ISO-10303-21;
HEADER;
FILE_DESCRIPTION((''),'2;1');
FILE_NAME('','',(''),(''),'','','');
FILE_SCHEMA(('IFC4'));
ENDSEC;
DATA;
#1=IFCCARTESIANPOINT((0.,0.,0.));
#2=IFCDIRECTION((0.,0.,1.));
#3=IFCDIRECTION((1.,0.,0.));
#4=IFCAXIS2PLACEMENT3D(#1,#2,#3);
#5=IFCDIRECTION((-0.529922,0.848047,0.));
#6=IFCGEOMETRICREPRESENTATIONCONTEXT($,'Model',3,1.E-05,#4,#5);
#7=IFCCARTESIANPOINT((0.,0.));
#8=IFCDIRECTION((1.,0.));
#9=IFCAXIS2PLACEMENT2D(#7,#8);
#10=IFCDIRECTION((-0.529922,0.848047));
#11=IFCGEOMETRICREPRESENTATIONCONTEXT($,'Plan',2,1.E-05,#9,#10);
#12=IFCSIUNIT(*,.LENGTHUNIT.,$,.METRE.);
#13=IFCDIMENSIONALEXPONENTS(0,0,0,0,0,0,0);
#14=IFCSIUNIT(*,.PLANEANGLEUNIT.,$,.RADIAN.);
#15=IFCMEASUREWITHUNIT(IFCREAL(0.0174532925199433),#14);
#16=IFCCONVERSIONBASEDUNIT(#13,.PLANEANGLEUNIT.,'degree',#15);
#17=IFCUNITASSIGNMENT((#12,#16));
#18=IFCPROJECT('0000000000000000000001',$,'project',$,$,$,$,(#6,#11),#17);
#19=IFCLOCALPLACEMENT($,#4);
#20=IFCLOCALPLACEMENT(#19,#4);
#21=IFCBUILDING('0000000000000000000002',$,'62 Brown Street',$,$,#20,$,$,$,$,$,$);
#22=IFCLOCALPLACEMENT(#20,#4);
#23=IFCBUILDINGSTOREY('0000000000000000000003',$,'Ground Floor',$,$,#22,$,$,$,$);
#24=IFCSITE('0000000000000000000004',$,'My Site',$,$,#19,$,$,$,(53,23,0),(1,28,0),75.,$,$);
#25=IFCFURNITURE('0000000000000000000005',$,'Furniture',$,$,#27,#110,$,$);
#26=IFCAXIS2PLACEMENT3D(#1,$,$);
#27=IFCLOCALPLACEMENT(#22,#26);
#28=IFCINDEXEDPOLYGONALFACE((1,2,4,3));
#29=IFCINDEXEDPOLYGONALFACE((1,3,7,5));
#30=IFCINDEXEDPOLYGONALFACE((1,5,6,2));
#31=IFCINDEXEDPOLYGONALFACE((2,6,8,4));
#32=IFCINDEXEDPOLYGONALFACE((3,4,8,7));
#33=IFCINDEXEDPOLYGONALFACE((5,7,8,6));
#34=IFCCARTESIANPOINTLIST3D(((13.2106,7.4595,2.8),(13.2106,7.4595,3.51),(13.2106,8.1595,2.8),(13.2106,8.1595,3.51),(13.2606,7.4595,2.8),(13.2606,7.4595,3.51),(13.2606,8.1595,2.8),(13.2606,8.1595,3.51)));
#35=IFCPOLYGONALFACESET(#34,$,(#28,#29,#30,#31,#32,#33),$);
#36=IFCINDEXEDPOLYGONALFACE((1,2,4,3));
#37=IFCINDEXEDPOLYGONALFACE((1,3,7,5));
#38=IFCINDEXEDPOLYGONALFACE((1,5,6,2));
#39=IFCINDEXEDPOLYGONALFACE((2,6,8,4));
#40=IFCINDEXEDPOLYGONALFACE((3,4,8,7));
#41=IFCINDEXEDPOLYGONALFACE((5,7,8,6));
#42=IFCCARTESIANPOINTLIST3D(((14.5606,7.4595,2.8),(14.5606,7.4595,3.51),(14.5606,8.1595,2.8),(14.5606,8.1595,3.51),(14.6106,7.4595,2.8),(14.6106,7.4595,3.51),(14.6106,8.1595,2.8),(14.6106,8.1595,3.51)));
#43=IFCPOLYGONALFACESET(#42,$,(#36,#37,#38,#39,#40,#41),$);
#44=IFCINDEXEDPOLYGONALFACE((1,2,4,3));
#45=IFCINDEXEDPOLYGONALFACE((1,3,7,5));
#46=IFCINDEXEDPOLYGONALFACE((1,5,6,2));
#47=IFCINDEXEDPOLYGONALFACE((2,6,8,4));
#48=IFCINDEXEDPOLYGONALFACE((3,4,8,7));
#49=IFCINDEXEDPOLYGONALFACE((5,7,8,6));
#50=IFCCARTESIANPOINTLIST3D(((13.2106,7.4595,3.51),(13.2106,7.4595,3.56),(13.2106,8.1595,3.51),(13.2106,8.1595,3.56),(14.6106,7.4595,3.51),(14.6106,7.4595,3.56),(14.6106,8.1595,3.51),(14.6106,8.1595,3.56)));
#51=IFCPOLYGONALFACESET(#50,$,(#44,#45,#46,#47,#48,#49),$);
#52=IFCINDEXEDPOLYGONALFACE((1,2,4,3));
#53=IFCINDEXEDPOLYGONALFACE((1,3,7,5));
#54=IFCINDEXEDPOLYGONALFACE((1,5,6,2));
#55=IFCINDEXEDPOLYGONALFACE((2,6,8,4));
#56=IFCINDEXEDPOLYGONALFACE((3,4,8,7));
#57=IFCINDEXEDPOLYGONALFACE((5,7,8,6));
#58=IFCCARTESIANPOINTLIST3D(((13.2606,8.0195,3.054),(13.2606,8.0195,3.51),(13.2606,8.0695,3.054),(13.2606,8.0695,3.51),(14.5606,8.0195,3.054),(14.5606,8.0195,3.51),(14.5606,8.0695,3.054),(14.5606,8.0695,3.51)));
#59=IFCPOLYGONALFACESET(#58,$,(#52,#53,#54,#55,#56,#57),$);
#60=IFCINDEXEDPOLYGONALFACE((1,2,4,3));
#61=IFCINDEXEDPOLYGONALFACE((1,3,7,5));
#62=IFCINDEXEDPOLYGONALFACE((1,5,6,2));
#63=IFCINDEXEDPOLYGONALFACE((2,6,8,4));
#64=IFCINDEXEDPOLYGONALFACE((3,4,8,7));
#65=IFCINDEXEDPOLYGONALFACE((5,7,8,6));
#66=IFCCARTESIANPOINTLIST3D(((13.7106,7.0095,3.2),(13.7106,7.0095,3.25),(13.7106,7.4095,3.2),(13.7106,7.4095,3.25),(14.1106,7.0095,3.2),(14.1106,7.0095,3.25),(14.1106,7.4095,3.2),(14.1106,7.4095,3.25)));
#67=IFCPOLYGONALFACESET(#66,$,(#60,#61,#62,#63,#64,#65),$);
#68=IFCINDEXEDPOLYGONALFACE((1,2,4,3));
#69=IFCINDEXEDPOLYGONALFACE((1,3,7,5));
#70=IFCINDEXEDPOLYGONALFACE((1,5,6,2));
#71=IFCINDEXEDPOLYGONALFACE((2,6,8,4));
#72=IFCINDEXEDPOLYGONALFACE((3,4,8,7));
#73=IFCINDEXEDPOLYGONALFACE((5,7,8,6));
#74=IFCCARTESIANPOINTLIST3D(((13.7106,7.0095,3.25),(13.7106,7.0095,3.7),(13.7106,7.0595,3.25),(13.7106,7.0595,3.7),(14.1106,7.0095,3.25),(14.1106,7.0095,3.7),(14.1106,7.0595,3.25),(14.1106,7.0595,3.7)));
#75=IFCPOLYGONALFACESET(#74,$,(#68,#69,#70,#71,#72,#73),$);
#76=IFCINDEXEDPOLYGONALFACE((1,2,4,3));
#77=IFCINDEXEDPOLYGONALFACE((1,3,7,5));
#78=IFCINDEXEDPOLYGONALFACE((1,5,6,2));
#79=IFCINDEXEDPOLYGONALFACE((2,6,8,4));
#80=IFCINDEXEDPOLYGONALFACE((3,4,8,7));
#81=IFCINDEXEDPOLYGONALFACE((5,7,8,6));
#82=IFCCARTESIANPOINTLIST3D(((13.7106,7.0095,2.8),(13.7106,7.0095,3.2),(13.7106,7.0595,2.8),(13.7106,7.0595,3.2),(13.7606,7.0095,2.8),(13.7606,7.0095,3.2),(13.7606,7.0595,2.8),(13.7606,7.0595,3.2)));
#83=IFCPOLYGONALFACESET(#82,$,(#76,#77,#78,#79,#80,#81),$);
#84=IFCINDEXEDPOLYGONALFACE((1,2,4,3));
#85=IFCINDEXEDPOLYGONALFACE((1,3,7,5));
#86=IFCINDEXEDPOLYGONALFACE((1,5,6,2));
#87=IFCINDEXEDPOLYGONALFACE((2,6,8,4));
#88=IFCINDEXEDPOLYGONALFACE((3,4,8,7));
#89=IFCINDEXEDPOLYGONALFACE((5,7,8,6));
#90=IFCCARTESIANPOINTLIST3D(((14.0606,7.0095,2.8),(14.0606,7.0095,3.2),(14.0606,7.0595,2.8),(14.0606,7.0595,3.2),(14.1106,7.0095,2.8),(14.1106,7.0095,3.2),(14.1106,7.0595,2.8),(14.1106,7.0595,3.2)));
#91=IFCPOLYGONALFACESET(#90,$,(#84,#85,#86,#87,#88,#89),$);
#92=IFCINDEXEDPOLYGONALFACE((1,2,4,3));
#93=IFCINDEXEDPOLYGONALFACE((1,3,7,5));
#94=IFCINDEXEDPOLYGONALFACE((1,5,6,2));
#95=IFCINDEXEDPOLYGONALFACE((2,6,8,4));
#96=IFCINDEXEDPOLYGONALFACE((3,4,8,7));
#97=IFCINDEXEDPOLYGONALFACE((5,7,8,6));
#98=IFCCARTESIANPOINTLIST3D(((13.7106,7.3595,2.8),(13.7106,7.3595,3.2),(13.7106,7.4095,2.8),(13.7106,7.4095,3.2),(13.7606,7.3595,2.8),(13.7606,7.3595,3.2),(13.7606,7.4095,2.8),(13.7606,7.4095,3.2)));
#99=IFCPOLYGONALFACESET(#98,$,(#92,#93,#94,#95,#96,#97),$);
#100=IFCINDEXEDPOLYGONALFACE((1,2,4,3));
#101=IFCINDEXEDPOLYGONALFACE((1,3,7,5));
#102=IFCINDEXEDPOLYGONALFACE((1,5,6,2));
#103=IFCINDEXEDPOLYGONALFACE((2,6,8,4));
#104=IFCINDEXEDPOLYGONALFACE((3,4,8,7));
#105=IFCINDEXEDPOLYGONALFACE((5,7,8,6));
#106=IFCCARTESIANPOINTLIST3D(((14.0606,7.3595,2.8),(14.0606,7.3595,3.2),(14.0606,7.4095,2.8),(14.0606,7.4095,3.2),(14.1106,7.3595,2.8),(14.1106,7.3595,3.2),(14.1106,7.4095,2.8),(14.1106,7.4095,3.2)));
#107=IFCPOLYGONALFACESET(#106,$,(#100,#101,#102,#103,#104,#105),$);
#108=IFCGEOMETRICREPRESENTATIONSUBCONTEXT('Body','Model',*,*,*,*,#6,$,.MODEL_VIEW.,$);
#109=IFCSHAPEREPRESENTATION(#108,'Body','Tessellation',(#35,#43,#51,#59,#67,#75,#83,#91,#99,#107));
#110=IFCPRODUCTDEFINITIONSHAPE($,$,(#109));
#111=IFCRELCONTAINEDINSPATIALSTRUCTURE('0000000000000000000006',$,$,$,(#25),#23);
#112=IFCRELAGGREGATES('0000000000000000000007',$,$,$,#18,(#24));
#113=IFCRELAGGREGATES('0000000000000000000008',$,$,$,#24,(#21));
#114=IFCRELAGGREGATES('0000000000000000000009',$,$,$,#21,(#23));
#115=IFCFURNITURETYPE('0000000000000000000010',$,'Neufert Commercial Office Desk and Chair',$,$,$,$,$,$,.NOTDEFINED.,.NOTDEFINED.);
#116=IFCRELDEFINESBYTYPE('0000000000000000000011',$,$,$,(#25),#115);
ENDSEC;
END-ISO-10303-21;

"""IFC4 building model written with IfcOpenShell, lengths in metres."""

from ifc_helpers import new_model, entity, si_unit, converted_unit, direction, frame, origin_with_axes, origin_2d_with_axis, place, context, subcontext, project, spatial, line, indexed_curve, outline, extrude, shape, source, transform, mapped, type_object, type_shapes, element, save


model = new_model("IFC4")

# Units and contexts
model_context = context("Model", 3, precision=1e-05, world=origin_with_axes(), true_north=direction((-0.529922, 0.848047, 0.0)))
plan_context = context("Plan", 2, precision=1e-05, world=origin_2d_with_axis(), true_north=direction((-0.529922, 0.848047)))
body_context_1 = subcontext(model_context, "Body", "Model", "MODEL_VIEW")
body_context_2 = subcontext(plan_context, "Body", "Plan", "PLAN_VIEW")
ifc_project = project(units=[si_unit("LENGTHUNIT", "METRE"), converted_unit("PLANEANGLEUNIT", "degree", entity("IfcReal", 0.0174532925199433), si_unit("PLANEANGLEUNIT", "RADIAN"), dimensions=[0, 0, 0, 0, 0, 0, 0])], contexts=[model_context, plan_context])

# Site, building, storey
site_placement = place(None, origin_with_axes())
site = spatial("IfcSite", under=ifc_project, at=site_placement, Name="My Site", RefLatitude=(53, 23, 0), RefLongitude=(1, 28, 0), RefElevation=75.0)
building_placement = place(site_placement, origin_with_axes())
building = spatial("IfcBuilding", under=site, at=building_placement, Name="62 Brown Street")
storey_placement = place(building_placement, origin_with_axes())
storey = spatial("IfcBuildingStorey", under=building, at=storey_placement, Name="Ground Floor")

# Furniture
furniture_type_1 = type_object("IfcFurnitureType", Name="Neufert Commercial Office Desk and Chair", AssemblyPlace="NOTDEFINED", PredefinedType="NOTDEFINED")
shared_shape_1 = source(origin_with_axes(), body_context_1, "Body", "SweptSolid", [
    extrude(outline(indexed_curve([(0.0, 0.0), (0.05, 0.0), (0.05, 0.7), (0.0, 0.7)], segments=[line(1, 2, 3, 4, 1)])), frame((0.0, 0.45, 0.0), z_axis=(0.0, 0.0, 1.0), x_axis=(1.0, 0.0, 0.0)), (0.0, 0.0, 1.0), 0.71),
    extrude(outline(indexed_curve([(0.0, 0.0), (0.05, 0.0), (0.05, 0.7), (0.0, 0.7)], segments=[line(1, 2, 3, 4, 1)])), frame((1.35, 0.45, 0.0), z_axis=(0.0, 0.0, 1.0), x_axis=(1.0, 0.0, 0.0)), (0.0, 0.0, 1.0), 0.71),
    extrude(outline(indexed_curve([(0.0, 0.0), (1.4, 0.0), (1.4, 0.7), (0.0, 0.7)], segments=[line(1, 2, 3, 4, 1)])), frame((0.0, 0.45, 0.71), z_axis=(0.0, 0.0, 1.0), x_axis=(1.0, 0.0, 0.0)), (0.0, 0.0, 1.0), 0.05),
    extrude(outline(indexed_curve([(0.05, 0.56), (1.35, 0.56), (1.35, 0.61), (0.05, 0.61)], segments=[line(1, 2, 3, 4, 1)])), frame((0.0, 0.45, 0.254), z_axis=(0.0, 0.0, 1.0), x_axis=(1.0, 0.0, 0.0)), (0.0, 0.0, 1.0), 0.456),
    extrude(outline(indexed_curve([(-0.2, 0.0), (0.2, 0.0), (0.2, 0.4), (-0.2, 0.4)], segments=[line(1, 2, 3, 4, 1)])), frame((0.7, 0.0, 0.45), z_axis=(0.0, 0.0, 1.0), x_axis=(1.0, 0.0, 0.0)), (0.0, 0.0, -1.0), 0.05),
    extrude(outline(indexed_curve([(-0.2, 0.0), (0.2, 0.0), (0.2, 0.05), (-0.2, 0.05)], segments=[line(1, 2, 3, 4, 1)])), frame((0.7, 0.0, 0.9), z_axis=(0.0, 0.0, 1.0), x_axis=(1.0, 0.0, 0.0)), (0.0, 0.0, -1.0), 0.45),
    extrude(outline(indexed_curve([(-0.2, 0.0), (-0.15, 0.0), (-0.15, 0.05), (-0.2, 0.05)], segments=[line(1, 2, 3, 4, 1)])), frame((0.7, 0.0, 0.0), z_axis=(0.0, 0.0, 1.0), x_axis=(1.0, 0.0, 0.0)), (0.0, 0.0, 1.0), 0.4),
    extrude(outline(indexed_curve([(0.2, 0.0), (0.15, 0.0), (0.15, 0.05), (0.2, 0.05)], segments=[line(1, 2, 3, 4, 1)])), frame((0.7, 0.0, 0.0), z_axis=(0.0, 0.0, 1.0), x_axis=(1.0, 0.0, 0.0)), (0.0, 0.0, 1.0), 0.4),
    extrude(outline(indexed_curve([(-0.2, 0.4), (-0.15, 0.4), (-0.15, 0.35), (-0.2, 0.35)], segments=[line(1, 2, 3, 4, 1)])), frame((0.7, 0.0, 0.0), z_axis=(0.0, 0.0, 1.0), x_axis=(1.0, 0.0, 0.0)), (0.0, 0.0, 1.0), 0.4),
    extrude(outline(indexed_curve([(0.2, 0.4), (0.15, 0.4), (0.15, 0.35), (0.2, 0.35)], segments=[line(1, 2, 3, 4, 1)])), frame((0.7, 0.0, 0.0), z_axis=(0.0, 0.0, 1.0), x_axis=(1.0, 0.0, 0.0)), (0.0, 0.0, 1.0), 0.4),
])
shared_shape_2 = source(origin_with_axes(), body_context_2, "Body", "Curve2D", [
    entity("IfcIndexedPolyCurve", entity("IfcCartesianPointList2D", [[0.0, 0.45], [1.4, 0.45], [1.4, 1.15], [0.0, 1.15]]), [entity("IfcLineIndex", [1, 2, 3, 4, 1])]),
    entity("IfcIndexedPolyCurve", entity("IfcCartesianPointList2D", [[0.5, 0.4], [0.9, 0.4]])),
    entity("IfcIndexedPolyCurve", entity("IfcCartesianPointList2D", [[0.5, 0.4], [0.5, 0.2], [0.5586, 0.0586], [0.7, 0.0], [0.8414, 0.0586], [0.9, 0.2], [0.9, 0.4]]), [entity("IfcLineIndex", [1, 2]), entity("IfcArcIndex", [2, 3, 4]), entity("IfcArcIndex", [4, 5, 6]), entity("IfcLineIndex", [6, 7])]),
    entity("IfcIndexedPolyCurve", entity("IfcCartesianPointList2D", [[0.54, 0.4], [0.54, 0.2], [0.5869, 0.0869], [0.7, 0.04], [0.8131, 0.0869], [0.86, 0.2], [0.86, 0.4]]), [entity("IfcLineIndex", [1, 2]), entity("IfcArcIndex", [2, 3, 4]), entity("IfcArcIndex", [4, 5, 6]), entity("IfcLineIndex", [6, 7])]),
])
type_shapes(furniture_type_1, [shared_shape_1, shared_shape_2])
furniture_1_placement = place(storey_placement, frame((13.2106, 7.0095, 2.8), z_axis=(0.0, 0.0, 1.0), x_axis=(1.0, 0.0, 0.0)))
element("IfcFurniture", 1, at=furniture_1_placement, inside=storey, type_object=furniture_type_1, Name="Furniture", shapes=[
    shape(body_context_1, "Body", "MappedRepresentation", [mapped(shared_shape_1, transform((0.0, 0.0, 0.0), x_axis=(1.0, 0.0, 0.0), y_axis=(0.0, 1.0, 0.0), z_axis=(0.0, 0.0, 1.0), scale=1.0))]),
    shape(body_context_2, "Body", "MappedRepresentation", [mapped(shared_shape_2, transform((0.0, 0.0, 0.0), x_axis=(1.0, 0.0, 0.0), y_axis=(0.0, 1.0, 0.0), z_axis=(0.0, 0.0, 1.0), scale=1.0))]),
])

save(model, "model.ifc")
